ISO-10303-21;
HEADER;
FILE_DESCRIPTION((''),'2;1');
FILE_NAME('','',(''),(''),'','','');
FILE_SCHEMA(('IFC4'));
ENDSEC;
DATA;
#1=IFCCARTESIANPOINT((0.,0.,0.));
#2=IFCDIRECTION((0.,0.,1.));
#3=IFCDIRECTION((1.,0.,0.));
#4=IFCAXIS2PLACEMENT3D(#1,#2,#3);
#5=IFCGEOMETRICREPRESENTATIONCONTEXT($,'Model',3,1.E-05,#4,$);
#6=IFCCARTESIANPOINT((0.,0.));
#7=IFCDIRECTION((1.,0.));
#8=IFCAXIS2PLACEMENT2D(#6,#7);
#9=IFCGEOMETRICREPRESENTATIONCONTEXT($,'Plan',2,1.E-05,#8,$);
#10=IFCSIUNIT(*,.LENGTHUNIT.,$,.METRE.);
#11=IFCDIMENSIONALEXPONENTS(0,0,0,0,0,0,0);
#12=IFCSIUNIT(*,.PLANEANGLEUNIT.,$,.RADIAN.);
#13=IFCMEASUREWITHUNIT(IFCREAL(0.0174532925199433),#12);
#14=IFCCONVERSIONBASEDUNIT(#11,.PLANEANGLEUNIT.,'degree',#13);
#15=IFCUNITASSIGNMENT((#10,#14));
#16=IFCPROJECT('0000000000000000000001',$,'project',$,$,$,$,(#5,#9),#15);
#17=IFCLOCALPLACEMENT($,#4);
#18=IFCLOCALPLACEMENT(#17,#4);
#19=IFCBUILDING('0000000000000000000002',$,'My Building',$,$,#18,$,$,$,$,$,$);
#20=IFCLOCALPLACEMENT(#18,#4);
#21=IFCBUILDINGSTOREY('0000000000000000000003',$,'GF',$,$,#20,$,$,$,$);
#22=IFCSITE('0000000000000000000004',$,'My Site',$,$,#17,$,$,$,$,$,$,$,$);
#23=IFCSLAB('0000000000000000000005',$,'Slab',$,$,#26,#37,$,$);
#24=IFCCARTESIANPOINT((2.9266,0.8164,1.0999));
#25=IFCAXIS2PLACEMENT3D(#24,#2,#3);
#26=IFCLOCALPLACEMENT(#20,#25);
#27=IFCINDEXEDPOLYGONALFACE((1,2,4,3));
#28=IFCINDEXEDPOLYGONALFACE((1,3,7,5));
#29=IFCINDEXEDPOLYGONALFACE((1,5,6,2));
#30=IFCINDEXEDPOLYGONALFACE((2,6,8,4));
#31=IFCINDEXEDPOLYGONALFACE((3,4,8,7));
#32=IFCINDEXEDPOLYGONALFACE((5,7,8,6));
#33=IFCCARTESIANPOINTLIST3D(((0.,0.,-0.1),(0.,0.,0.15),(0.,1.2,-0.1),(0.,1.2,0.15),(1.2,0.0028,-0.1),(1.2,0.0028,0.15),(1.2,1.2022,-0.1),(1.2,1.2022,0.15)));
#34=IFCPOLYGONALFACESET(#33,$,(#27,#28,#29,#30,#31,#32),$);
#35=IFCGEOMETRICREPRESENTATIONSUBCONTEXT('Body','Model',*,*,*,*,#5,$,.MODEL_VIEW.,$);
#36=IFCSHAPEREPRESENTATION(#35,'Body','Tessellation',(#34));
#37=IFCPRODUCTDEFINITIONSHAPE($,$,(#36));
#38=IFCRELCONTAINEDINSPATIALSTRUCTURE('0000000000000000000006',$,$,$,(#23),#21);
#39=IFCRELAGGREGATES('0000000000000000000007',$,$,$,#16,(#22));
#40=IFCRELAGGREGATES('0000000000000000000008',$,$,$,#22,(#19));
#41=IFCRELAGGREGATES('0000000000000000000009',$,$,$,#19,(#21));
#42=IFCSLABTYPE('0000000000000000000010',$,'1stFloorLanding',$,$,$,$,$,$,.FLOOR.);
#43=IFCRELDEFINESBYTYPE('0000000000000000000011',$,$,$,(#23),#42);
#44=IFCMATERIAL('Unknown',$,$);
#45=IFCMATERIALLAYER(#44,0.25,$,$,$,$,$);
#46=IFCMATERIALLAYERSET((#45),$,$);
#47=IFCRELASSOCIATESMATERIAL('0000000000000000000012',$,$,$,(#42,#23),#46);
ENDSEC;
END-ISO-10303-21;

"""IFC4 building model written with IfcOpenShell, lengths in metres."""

from ifc_helpers import new_model, entity, si_unit, converted_unit, frame, origin_with_axes, origin_2d_with_axis, place, context, subcontext, project, spatial, indexed_curve, outline, extrude, material, layer, layer_set, layer_usage, type_object, element, save


model = new_model("IFC4")

# Units and contexts
model_context = context("Model", 3, precision=1e-05, world=origin_with_axes())
plan_context = context("Plan", 2, precision=1e-05, world=origin_2d_with_axis())
body_context_1 = subcontext(model_context, "Body", "Model", "MODEL_VIEW")
ifc_project = project(units=[si_unit("LENGTHUNIT", "METRE"), converted_unit("PLANEANGLEUNIT", "degree", entity("IfcReal", 0.0174532925199433), si_unit("PLANEANGLEUNIT", "RADIAN"), dimensions=[0, 0, 0, 0, 0, 0, 0])], contexts=[model_context, plan_context])

# Site, building, storey
site_placement = place(None, origin_with_axes())
site = spatial("IfcSite", under=ifc_project, at=site_placement, Name="My Site")
building_placement = place(site_placement, origin_with_axes())
building = spatial("IfcBuilding", under=site, at=building_placement, Name="My Building")
storey_placement = place(building_placement, origin_with_axes())
storey = spatial("IfcBuildingStorey", under=building, at=storey_placement, Name="GF")

# Shared definitions
ifc_material_1 = material(Name="Unknown")

# Slab
ifc_layer_1 = layer(ifc_material_1, 0.25)
ifc_layer_set_1 = layer_set([ifc_layer_1])
ifc_layer_usage_1 = layer_usage(ifc_layer_set_1, "AXIS3", "POSITIVE", -0.1)
slab_type_1 = type_object("IfcSlabType", Name="1stFloorLanding", PredefinedType="FLOOR", material=ifc_layer_set_1)
slab_1_placement = place(storey_placement, frame((2.9266, 0.8164, 1.0999), z_axis=(0.0, 0.0, 1.0), x_axis=(1.0, 0.0, 0.0)))
element("IfcSlab", 1, at=slab_1_placement, inside=storey, type_object=slab_type_1, material=ifc_layer_usage_1, Name="Slab", context=body_context_1, shape_type="SweptSolid", body=[
    extrude(outline(indexed_curve([(0.0, 0.0), (0.0, 1.2), (1.2, 1.2022), (1.2, 0.0028), (0.0, 0.0)])), frame((0.0, 0.0, -0.1), z_axis=(0.0, 0.0, 1.0), x_axis=(1.0, 0.0, 0.0)), (0.0, 0.0, 1.0), 0.25),
])

save(model, "model.ifc")
